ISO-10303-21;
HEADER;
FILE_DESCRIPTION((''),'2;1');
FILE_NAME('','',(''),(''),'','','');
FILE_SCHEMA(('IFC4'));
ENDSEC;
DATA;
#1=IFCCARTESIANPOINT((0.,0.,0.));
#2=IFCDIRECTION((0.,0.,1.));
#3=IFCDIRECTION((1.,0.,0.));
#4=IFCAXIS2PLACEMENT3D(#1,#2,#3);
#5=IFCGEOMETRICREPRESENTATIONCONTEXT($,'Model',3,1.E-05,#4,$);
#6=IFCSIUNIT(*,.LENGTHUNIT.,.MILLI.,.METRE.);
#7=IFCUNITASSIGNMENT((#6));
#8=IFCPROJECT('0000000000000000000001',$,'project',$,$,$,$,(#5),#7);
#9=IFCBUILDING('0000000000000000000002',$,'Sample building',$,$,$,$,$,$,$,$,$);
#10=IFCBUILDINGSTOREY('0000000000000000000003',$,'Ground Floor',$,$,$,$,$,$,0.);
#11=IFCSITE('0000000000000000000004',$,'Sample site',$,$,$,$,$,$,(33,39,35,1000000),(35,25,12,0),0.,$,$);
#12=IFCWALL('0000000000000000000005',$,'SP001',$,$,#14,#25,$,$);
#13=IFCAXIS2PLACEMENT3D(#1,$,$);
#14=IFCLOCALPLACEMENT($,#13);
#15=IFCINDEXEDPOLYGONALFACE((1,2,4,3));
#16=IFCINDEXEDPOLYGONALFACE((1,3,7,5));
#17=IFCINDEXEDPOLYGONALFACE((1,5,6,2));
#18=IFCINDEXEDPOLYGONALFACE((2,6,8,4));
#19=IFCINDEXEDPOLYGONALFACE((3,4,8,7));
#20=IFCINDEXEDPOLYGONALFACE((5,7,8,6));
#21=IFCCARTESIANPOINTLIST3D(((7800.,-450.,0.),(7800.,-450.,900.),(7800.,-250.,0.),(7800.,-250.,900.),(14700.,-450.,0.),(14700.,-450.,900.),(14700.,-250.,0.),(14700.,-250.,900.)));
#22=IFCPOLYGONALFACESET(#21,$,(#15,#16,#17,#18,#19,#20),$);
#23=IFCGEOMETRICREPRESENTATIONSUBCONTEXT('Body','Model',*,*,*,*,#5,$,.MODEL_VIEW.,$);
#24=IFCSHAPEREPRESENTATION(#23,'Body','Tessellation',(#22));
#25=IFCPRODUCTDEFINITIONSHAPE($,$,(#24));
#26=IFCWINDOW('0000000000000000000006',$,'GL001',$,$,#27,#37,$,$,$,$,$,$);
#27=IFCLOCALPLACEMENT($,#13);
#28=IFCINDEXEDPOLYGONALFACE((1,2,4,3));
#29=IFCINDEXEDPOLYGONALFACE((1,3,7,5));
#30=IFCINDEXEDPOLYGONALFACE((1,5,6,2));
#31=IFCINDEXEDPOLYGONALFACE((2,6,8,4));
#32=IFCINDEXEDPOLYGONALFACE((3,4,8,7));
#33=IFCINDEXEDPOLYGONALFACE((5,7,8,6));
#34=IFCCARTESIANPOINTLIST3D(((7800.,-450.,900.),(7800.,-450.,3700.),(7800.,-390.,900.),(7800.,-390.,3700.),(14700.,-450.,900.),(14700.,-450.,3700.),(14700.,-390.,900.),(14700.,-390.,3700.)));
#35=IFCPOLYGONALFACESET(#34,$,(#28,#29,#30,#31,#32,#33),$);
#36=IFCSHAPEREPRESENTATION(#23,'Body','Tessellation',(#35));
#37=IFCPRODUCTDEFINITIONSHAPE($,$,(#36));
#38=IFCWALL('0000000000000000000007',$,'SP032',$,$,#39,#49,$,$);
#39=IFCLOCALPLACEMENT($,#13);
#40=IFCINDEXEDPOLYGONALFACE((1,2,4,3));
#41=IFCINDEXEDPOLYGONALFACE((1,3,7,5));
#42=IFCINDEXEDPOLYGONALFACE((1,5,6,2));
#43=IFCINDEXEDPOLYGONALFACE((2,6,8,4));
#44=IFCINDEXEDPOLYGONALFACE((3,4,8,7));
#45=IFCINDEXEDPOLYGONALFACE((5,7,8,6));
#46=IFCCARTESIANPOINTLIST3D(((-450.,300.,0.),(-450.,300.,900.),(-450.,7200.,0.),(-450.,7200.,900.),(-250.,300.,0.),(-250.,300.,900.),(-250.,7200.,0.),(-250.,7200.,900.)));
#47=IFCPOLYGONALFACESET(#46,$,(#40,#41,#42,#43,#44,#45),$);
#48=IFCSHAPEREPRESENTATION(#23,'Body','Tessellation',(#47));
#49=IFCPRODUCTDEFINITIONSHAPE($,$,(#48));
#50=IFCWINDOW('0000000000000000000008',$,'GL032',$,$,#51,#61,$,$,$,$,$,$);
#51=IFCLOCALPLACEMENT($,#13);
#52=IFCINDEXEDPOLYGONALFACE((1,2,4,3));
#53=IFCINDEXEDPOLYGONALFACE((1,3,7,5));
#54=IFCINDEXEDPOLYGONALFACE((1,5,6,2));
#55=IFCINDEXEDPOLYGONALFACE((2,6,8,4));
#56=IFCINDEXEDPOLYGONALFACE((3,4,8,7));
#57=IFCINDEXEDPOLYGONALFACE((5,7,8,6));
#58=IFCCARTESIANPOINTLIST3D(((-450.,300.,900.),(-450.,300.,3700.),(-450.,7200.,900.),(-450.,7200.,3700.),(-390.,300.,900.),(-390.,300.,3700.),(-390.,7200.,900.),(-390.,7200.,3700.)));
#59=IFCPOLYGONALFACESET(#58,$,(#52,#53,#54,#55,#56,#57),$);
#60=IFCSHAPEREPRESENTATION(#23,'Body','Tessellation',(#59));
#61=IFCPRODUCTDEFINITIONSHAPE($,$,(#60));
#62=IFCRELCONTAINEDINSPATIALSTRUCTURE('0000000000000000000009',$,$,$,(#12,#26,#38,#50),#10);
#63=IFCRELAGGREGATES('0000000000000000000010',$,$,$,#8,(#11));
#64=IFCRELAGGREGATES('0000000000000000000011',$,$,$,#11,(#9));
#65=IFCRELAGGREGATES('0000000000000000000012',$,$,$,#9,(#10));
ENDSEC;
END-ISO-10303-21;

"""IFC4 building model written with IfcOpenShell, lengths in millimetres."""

from ifc_helpers import new_model, si_unit, frame, origin_with_axes, place, context, subcontext, project, spatial, indexed_curve, outline, extrude, element, save


model = new_model("IFC4")

# Units and contexts
model_context = context("Model", 3, precision=1e-05, world=origin_with_axes())
body_context = subcontext(model_context, "Body", "Model", "MODEL_VIEW")
ifc_project = project(units=[si_unit("LENGTHUNIT", "METRE", prefix="MILLI")], contexts=[model_context])

# Site, building, storey
site = spatial("IfcSite", under=ifc_project, Name="Sample site", RefLatitude=(33, 39, 35, 1000000), RefLongitude=(35, 25, 12, 0), RefElevation=0.0)
building = spatial("IfcBuilding", under=site, Name="Sample building")
storey = spatial("IfcBuildingStorey", under=building, Name="Ground Floor", Elevation=0.0)

# Wall
wall_1_placement = place(None, frame((7800.0, -450.0, 0.0), z_axis=(0.0, 0.0, 1.0), x_axis=(1.0, 0.0, 0.0)))
element("IfcWall", 1, at=wall_1_placement, inside=storey, Name="SP001", context=body_context, shape_type="SweptSolid", body=[
    extrude(outline(indexed_curve([(0.0, 0.0), (0.0, 200.0), (6900.0, 200.0), (6900.0, 0.0), (0.0, 0.0)], self_intersect=False)), origin_with_axes(), (0.0, 0.0, 1.0), 900.0),
])

# Window
window_1_placement = place(None, frame((7800.0, -450.0, 900.0), z_axis=(0.0, 0.0, 1.0), x_axis=(1.0, 0.0, 0.0)))
element("IfcWindow", 2, at=window_1_placement, inside=storey, Name="GL001", context=body_context, shape_type="SweptSolid", body=[
    extrude(outline(indexed_curve([(0.0, 0.0), (0.0, 60.0), (6900.0, 60.0), (6900.0, 0.0), (0.0, 0.0)], self_intersect=False)), origin_with_axes(), (0.0, 0.0, 1.0), 2800.0),
])

# Wall
wall_2_placement = place(None, frame((-450.0, 7200.0, 0.0), z_axis=(0.0, 0.0, 1.0), x_axis=(0.0, -1.0, 0.0)))
element("IfcWall", 3, at=wall_2_placement, inside=storey, Name="SP032", context=body_context, shape_type="SweptSolid", body=[
    extrude(outline(indexed_curve([(0.0, 0.0), (0.0, 200.0), (6900.0, 200.0), (6900.0, 0.0), (0.0, 0.0)], self_intersect=False)), origin_with_axes(), (0.0, 0.0, 1.0), 900.0),
])

# Window
window_2_placement = place(None, frame((-450.0, 7200.0, 900.0), z_axis=(0.0, 0.0, 1.0), x_axis=(0.0, -1.0, 0.0)))
element("IfcWindow", 4, at=window_2_placement, inside=storey, Name="GL032", context=body_context, shape_type="SweptSolid", body=[
    extrude(outline(indexed_curve([(0.0, 0.0), (0.0, 60.0), (6900.0, 60.0), (6900.0, 0.0), (0.0, 0.0)], self_intersect=False)), origin_with_axes(), (0.0, 0.0, 1.0), 2800.0),
])

save(model, "model.ifc")
